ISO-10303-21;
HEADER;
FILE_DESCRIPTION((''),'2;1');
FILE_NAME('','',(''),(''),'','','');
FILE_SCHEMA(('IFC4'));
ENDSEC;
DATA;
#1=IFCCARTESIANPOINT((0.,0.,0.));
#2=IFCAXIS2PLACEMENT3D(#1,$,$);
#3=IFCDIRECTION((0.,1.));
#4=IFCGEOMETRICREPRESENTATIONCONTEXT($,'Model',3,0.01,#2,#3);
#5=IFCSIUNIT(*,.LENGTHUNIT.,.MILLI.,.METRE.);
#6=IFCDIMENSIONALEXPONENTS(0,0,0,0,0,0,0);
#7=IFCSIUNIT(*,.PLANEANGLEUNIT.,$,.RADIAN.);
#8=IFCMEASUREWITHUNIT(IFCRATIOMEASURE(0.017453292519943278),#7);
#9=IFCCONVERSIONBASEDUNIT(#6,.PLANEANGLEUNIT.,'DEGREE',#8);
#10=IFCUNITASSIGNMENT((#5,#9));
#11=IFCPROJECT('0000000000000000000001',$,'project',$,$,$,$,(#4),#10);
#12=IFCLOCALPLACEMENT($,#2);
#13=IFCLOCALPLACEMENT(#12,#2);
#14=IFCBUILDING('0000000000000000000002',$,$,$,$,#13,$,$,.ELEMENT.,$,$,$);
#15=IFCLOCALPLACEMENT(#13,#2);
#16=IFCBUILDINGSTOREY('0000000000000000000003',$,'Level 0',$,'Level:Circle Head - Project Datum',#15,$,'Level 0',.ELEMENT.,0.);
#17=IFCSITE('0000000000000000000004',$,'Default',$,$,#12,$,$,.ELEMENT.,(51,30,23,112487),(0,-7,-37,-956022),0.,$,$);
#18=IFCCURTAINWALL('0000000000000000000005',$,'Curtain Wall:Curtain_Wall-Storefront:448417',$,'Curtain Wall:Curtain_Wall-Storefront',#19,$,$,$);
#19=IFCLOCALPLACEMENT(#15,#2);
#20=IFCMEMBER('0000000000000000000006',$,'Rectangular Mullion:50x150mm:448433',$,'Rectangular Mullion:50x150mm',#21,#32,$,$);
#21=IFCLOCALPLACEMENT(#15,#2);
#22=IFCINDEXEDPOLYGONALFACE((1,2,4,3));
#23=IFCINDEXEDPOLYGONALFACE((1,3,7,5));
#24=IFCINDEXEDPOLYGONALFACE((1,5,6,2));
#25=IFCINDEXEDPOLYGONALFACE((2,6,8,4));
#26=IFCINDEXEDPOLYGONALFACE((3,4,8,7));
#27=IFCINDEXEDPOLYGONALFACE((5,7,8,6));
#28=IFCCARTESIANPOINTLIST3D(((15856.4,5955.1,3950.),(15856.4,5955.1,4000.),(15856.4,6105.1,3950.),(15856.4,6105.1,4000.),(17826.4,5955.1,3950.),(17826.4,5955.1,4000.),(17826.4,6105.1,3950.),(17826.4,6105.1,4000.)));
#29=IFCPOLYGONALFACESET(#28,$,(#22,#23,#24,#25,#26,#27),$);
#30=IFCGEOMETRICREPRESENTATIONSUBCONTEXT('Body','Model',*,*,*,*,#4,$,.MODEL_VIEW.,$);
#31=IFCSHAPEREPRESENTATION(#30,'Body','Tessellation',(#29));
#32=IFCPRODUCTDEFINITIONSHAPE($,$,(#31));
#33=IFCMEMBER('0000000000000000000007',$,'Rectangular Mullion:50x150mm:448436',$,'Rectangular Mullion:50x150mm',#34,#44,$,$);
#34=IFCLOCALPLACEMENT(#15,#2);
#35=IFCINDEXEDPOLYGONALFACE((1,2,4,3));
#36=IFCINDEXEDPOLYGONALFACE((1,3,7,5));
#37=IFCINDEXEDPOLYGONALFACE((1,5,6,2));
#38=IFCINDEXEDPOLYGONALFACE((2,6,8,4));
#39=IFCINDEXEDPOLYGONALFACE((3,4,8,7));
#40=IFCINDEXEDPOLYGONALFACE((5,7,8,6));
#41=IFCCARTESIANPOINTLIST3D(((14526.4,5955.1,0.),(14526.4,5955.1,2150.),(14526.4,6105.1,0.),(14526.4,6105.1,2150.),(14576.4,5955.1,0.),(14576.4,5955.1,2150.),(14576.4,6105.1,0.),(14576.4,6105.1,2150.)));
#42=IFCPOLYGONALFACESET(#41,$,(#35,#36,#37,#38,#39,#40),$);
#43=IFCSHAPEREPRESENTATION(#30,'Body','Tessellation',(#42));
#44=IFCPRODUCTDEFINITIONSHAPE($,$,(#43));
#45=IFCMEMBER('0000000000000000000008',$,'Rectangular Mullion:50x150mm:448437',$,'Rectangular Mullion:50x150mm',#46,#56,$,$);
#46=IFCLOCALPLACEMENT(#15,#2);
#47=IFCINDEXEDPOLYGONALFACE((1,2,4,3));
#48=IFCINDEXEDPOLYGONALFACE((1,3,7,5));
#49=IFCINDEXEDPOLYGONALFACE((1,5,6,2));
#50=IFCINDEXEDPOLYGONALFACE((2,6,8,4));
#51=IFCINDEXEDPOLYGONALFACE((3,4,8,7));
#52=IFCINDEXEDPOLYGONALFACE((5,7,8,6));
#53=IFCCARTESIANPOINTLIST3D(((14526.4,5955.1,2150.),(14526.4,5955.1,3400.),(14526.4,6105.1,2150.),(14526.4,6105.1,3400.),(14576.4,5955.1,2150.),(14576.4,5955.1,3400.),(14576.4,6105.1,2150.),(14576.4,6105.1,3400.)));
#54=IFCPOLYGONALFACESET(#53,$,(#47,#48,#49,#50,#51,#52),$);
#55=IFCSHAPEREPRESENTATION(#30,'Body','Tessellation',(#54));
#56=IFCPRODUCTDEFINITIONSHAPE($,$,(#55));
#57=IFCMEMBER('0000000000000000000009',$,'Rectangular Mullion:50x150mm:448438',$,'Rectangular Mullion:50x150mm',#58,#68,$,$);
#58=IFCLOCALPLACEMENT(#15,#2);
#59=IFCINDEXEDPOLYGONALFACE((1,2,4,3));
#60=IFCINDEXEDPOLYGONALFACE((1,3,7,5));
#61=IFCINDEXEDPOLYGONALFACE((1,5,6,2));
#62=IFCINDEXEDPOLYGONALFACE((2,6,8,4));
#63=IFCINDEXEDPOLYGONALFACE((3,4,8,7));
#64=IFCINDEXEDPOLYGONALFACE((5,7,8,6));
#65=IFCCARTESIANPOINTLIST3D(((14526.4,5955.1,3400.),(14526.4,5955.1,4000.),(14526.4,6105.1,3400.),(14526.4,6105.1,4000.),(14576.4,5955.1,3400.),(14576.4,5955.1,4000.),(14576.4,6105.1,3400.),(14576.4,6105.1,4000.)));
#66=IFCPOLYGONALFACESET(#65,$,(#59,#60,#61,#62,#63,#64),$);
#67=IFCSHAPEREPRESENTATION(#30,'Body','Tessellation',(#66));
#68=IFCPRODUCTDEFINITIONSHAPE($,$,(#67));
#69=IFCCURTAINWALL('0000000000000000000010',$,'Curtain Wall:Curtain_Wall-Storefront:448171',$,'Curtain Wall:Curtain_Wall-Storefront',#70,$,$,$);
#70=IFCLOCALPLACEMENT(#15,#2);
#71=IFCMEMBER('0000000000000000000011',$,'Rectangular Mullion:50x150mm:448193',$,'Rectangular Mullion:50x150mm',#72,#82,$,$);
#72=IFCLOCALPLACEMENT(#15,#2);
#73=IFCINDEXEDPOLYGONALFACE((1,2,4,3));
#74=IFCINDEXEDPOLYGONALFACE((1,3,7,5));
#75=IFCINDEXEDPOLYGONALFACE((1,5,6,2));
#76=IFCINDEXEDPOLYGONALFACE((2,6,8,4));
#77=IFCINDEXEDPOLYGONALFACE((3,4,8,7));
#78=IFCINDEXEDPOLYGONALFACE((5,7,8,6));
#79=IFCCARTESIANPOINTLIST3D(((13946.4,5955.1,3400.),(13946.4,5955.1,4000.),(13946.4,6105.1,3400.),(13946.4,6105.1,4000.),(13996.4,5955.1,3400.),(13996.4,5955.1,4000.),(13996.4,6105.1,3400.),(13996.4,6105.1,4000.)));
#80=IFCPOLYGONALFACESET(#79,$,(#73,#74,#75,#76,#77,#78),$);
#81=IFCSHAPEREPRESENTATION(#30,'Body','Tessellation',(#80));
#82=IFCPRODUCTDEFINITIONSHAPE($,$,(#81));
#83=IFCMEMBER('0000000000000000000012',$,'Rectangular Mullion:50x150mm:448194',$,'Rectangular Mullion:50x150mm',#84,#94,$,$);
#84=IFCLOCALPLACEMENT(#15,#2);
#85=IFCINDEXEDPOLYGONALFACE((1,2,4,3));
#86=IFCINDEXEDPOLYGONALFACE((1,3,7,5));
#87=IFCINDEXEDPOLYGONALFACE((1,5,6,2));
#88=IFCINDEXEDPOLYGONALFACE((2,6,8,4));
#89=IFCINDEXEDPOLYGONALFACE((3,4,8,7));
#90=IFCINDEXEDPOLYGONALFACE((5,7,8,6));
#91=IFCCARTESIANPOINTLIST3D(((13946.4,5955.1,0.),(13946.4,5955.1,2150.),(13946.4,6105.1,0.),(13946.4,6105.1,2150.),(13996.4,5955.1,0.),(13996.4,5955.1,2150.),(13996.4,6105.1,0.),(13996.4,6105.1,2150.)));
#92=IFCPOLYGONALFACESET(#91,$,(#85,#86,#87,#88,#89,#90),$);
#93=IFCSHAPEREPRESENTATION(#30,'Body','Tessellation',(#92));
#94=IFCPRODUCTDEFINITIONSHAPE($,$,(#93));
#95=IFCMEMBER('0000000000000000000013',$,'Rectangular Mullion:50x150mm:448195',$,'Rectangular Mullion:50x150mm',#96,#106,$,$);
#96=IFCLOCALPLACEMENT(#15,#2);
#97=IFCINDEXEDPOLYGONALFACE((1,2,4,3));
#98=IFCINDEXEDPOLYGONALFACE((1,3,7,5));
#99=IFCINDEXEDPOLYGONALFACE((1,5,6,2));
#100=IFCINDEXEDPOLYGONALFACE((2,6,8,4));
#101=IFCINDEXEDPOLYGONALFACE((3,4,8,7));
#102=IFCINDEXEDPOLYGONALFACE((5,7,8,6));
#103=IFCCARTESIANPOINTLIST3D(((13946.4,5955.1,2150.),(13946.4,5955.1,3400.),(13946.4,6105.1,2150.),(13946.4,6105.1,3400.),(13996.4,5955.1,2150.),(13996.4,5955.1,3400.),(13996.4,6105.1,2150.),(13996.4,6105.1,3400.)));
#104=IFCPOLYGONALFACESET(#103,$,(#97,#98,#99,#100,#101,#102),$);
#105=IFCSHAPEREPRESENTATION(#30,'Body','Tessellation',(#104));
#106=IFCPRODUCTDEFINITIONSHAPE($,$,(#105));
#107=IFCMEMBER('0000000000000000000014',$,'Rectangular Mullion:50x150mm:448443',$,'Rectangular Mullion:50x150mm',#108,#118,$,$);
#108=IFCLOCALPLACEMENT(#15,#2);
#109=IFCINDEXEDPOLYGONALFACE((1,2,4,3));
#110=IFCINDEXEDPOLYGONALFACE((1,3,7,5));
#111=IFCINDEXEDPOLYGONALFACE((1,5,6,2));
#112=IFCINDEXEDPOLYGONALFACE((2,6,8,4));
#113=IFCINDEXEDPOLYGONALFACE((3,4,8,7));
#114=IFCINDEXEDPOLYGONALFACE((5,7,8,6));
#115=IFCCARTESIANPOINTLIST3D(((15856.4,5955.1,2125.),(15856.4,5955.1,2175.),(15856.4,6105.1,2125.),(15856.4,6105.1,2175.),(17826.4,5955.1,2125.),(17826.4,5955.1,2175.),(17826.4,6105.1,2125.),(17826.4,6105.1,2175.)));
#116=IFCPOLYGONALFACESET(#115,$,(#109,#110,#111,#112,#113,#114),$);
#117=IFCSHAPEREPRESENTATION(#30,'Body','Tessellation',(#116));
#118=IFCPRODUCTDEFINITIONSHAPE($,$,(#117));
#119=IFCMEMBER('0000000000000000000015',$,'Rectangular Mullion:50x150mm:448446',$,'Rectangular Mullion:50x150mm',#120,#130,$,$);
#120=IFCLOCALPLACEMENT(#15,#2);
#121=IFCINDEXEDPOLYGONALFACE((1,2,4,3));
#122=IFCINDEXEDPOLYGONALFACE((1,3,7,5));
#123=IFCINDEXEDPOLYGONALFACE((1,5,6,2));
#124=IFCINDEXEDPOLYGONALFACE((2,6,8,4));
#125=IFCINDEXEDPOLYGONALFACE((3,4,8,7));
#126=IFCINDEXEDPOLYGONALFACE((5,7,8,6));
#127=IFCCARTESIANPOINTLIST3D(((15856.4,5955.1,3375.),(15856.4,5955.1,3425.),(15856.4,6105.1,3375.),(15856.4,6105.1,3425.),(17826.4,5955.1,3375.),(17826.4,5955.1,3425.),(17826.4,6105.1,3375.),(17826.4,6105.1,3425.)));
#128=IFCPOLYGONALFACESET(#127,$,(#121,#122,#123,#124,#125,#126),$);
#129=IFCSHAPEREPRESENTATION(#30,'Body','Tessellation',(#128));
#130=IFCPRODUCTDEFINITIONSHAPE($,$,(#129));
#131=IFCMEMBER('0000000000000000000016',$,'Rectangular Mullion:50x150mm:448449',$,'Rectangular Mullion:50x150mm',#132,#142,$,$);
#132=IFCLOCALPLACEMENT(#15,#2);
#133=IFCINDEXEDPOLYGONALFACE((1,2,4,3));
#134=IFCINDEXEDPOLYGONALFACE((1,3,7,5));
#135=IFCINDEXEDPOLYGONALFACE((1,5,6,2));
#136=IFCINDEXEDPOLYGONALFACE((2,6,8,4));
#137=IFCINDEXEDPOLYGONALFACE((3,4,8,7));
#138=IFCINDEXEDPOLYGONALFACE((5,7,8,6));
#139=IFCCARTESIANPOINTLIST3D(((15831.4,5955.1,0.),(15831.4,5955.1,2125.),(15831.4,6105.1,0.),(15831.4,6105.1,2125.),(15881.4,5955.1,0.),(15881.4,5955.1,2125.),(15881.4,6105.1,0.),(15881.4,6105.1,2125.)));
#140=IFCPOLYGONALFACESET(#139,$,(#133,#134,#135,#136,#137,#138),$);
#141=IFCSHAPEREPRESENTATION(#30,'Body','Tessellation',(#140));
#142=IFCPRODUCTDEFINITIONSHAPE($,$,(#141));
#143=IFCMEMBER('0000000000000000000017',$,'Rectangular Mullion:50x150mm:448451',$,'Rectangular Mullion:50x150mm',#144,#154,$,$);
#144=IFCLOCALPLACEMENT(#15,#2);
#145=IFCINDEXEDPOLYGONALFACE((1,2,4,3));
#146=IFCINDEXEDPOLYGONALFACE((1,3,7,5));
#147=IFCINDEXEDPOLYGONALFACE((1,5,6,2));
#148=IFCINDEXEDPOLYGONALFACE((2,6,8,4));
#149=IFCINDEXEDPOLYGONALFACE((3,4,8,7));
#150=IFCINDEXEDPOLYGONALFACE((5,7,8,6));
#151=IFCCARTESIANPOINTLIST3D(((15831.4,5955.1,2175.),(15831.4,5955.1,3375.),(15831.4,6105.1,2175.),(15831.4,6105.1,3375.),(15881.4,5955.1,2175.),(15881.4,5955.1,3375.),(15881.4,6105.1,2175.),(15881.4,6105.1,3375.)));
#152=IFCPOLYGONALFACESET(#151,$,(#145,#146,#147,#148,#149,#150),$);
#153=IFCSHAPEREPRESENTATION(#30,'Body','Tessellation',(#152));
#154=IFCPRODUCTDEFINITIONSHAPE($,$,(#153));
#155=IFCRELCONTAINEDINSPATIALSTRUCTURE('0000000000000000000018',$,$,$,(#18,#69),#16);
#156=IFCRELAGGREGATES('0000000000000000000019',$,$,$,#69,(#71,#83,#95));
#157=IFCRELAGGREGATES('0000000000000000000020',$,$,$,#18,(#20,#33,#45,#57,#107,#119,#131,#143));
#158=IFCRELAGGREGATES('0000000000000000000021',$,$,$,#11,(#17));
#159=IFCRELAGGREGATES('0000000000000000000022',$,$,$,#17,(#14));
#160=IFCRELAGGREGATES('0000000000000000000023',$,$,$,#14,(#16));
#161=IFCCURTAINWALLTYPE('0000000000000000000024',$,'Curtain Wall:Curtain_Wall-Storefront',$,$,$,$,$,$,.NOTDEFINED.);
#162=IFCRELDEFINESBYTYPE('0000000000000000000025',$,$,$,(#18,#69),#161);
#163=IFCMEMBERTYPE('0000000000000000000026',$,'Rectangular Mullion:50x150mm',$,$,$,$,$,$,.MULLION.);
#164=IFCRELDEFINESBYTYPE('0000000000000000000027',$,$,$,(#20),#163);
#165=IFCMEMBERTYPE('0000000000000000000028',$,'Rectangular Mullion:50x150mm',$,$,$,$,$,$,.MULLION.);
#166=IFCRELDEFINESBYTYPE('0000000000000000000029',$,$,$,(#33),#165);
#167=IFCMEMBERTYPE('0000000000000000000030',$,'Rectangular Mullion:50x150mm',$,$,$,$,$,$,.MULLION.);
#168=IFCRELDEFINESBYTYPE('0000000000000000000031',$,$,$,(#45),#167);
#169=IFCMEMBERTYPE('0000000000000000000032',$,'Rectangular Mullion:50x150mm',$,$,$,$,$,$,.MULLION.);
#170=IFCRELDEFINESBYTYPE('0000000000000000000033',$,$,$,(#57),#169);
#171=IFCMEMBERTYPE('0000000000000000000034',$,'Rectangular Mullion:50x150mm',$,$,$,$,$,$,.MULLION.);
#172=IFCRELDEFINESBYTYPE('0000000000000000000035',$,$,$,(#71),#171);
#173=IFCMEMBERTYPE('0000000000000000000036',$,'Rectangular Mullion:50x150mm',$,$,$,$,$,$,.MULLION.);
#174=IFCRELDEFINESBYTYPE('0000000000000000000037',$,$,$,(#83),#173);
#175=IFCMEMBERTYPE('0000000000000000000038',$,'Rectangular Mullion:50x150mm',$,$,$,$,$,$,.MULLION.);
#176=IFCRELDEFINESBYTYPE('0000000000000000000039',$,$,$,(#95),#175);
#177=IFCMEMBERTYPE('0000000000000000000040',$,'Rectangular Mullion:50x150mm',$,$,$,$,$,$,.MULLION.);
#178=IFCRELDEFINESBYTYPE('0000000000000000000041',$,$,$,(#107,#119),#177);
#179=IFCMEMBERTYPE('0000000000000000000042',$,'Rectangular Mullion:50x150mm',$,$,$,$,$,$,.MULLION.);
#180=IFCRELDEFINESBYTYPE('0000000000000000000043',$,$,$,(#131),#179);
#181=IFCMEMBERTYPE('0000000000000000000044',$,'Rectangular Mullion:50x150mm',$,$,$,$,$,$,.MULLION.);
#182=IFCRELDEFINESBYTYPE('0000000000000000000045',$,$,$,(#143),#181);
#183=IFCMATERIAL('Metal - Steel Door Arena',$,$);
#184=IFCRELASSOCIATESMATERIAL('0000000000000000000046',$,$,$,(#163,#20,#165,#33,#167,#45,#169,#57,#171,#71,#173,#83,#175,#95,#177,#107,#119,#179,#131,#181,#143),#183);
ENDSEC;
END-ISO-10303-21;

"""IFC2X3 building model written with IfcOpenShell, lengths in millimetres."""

from ifc_helpers import new_model, entity, si_unit, converted_unit, direction, frame, origin, origin_2d_with_axis, place, context, subcontext, project, spatial, rectangle, extrude, source, transform, mapped, material, type_object, type_shapes, element, aggregate, save


model = new_model("IFC2X3")

# Units and contexts
model_context = context("Model", 3, precision=0.01, world=origin(), true_north=direction((0.0, 1.0)))
body_context = subcontext(model_context, "Body", "Model", "MODEL_VIEW")
ifc_project = project(units=[si_unit("LENGTHUNIT", "METRE", prefix="MILLI"), converted_unit("PLANEANGLEUNIT", "DEGREE", entity("IfcRatioMeasure", 0.017453292519943278), si_unit("PLANEANGLEUNIT", "RADIAN"), dimensions=[0, 0, 0, 0, 0, 0, 0])], contexts=[model_context])

# Site, building, storey
site_placement = place(None, origin())
site = spatial("IfcSite", under=ifc_project, at=site_placement, Name="Default", CompositionType="ELEMENT", RefLatitude=(51, 30, 23, 112487), RefLongitude=(0, -7, -37, -956022), RefElevation=0.0)
building_placement = place(site_placement, origin())
building = spatial("IfcBuilding", under=site, at=building_placement, CompositionType="ELEMENT")
storey_placement = place(building_placement, origin())
storey = spatial("IfcBuildingStorey", under=building, at=storey_placement, Name="Level 0", ObjectType="Level:Circle Head - Project Datum", LongName="Level 0", CompositionType="ELEMENT", Elevation=0.0)

# Curtain walls, members
curtain_wall_type = type_object("IfcCurtainWallType", Name="Curtain Wall:Curtain_Wall-Storefront", PredefinedType="NOTDEFINED")
curtain_wall_1_placement = place(storey_placement, origin())
curtain_wall_1 = element("IfcCurtainWall", 1, at=curtain_wall_1_placement, inside=storey, type_object=curtain_wall_type, Name="Curtain Wall:Curtain_Wall-Storefront:448417", ObjectType="Curtain Wall:Curtain_Wall-Storefront")
ifc_material_1 = material(Name="Metal - Steel Door Arena")
member_type_1 = type_object("IfcMemberType", Name="Rectangular Mullion:50x150mm", PredefinedType="MULLION", material=ifc_material_1)
shared_shape_1 = source(origin(), body_context, "Body", "SweptSolid", [
    extrude(rectangle(XDim=150.0, YDim=50.0, at=origin_2d_with_axis()), frame((-25.0, 0.0, -1970.0), z_axis=(0.0, 0.0, 1.0), x_axis=(0.0, -1.0, 0.0)), (0.0, 0.0, 1.0), 1970.0),
])
type_shapes(member_type_1, [shared_shape_1])
member_1_placement = place(curtain_wall_1_placement, frame((15856.4, 6030.1, 4000.0), z_axis=(-1.0, 0.0, 0.0), x_axis=(0.0, 0.0, 1.0)))
member_1 = element("IfcMember", 2, at=member_1_placement, type_object=member_type_1, material=ifc_material_1, Name="Rectangular Mullion:50x150mm:448433", ObjectType="Rectangular Mullion:50x150mm", context=body_context, shape_type="MappedRepresentation", body=[
    mapped(shared_shape_1, transform((0.0, 0.0, 0.0), scale=1.0)),
])
member_type_2 = type_object("IfcMemberType", Name="Rectangular Mullion:50x150mm", PredefinedType="MULLION", material=ifc_material_1)
shared_shape_2 = source(origin(), body_context, "Body", "SweptSolid", [
    extrude(rectangle(XDim=150.0, YDim=50.0, at=origin_2d_with_axis()), frame((-25.0, 0.0, -2150.0), z_axis=(0.0, 0.0, 1.0), x_axis=(0.0, -1.0, 0.0)), (0.0, 0.0, 1.0), 2150.0),
])
type_shapes(member_type_2, [shared_shape_2])
member_2_placement = place(curtain_wall_1_placement, frame((14526.4, 6030.1, 0.0), z_axis=(0.0, 0.0, -1.0), x_axis=(-1.0, 0.0, 0.0)))
member_2 = element("IfcMember", 3, at=member_2_placement, type_object=member_type_2, material=ifc_material_1, Name="Rectangular Mullion:50x150mm:448436", ObjectType="Rectangular Mullion:50x150mm", context=body_context, shape_type="MappedRepresentation", body=[
    mapped(shared_shape_2, transform((0.0, 0.0, 0.0), scale=1.0)),
])
member_type_3 = type_object("IfcMemberType", Name="Rectangular Mullion:50x150mm", PredefinedType="MULLION", material=ifc_material_1)
shared_shape_3 = source(origin(), body_context, "Body", "SweptSolid", [
    extrude(rectangle(XDim=150.0, YDim=50.0, at=origin_2d_with_axis()), frame((-25.0, 0.0, -1250.0), z_axis=(0.0, 0.0, 1.0), x_axis=(0.0, -1.0, 0.0)), (0.0, 0.0, 1.0), 1250.0),
])
type_shapes(member_type_3, [shared_shape_3])
member_3_placement = place(curtain_wall_1_placement, frame((14526.4, 6030.1, 2150.0), z_axis=(0.0, 0.0, -1.0), x_axis=(-1.0, 0.0, 0.0)))
member_3 = element("IfcMember", 4, at=member_3_placement, type_object=member_type_3, material=ifc_material_1, Name="Rectangular Mullion:50x150mm:448437", ObjectType="Rectangular Mullion:50x150mm", context=body_context, shape_type="MappedRepresentation", body=[
    mapped(shared_shape_3, transform((0.0, 0.0, 0.0), scale=1.0)),
])
member_type_4 = type_object("IfcMemberType", Name="Rectangular Mullion:50x150mm", PredefinedType="MULLION", material=ifc_material_1)
shared_shape_4 = source(origin(), body_context, "Body", "SweptSolid", [
    extrude(rectangle(XDim=150.0, YDim=50.0, at=origin_2d_with_axis()), frame((-25.0, 0.0, -600.0), z_axis=(0.0, 0.0, 1.0), x_axis=(0.0, -1.0, 0.0)), (0.0, 0.0, 1.0), 600.0),
])
type_shapes(member_type_4, [shared_shape_4])
member_4_placement = place(curtain_wall_1_placement, frame((14526.4, 6030.1, 3400.0), z_axis=(0.0, 0.0, -1.0), x_axis=(-1.0, 0.0, 0.0)))
member_4 = element("IfcMember", 5, at=member_4_placement, type_object=member_type_4, material=ifc_material_1, Name="Rectangular Mullion:50x150mm:448438", ObjectType="Rectangular Mullion:50x150mm", context=body_context, shape_type="MappedRepresentation", body=[
    mapped(shared_shape_4, transform((0.0, 0.0, 0.0), scale=1.0)),
])
curtain_wall_2_placement = place(storey_placement, origin())
curtain_wall_2 = element("IfcCurtainWall", 6, at=curtain_wall_2_placement, inside=storey, type_object=curtain_wall_type, Name="Curtain Wall:Curtain_Wall-Storefront:448171", ObjectType="Curtain Wall:Curtain_Wall-Storefront")
member_type_5 = type_object("IfcMemberType", Name="Rectangular Mullion:50x150mm", PredefinedType="MULLION", material=ifc_material_1)
shared_shape_5 = source(origin(), body_context, "Body", "SweptSolid", [
    extrude(rectangle(XDim=150.0, YDim=50.0, at=origin_2d_with_axis()), frame((-25.0, 0.0, -600.0), z_axis=(0.0, 0.0, 1.0), x_axis=(0.0, -1.0, 0.0)), (0.0, 0.0, 1.0), 600.0),
])
type_shapes(member_type_5, [shared_shape_5])
member_5_placement = place(curtain_wall_2_placement, frame((13996.4, 6030.1, 4000.0)))
member_5 = element("IfcMember", 7, at=member_5_placement, type_object=member_type_5, material=ifc_material_1, Name="Rectangular Mullion:50x150mm:448193", ObjectType="Rectangular Mullion:50x150mm", context=body_context, shape_type="MappedRepresentation", body=[
    mapped(shared_shape_5, transform((0.0, 0.0, 0.0), scale=1.0)),
])
member_type_6 = type_object("IfcMemberType", Name="Rectangular Mullion:50x150mm", PredefinedType="MULLION", material=ifc_material_1)
shared_shape_6 = source(origin(), body_context, "Body", "SweptSolid", [
    extrude(rectangle(XDim=150.0, YDim=50.0, at=origin_2d_with_axis()), frame((-25.0, 0.0, -2150.0), z_axis=(0.0, 0.0, 1.0), x_axis=(0.0, -1.0, 0.0)), (0.0, 0.0, 1.0), 2150.0),
])
type_shapes(member_type_6, [shared_shape_6])
member_6_placement = place(curtain_wall_2_placement, frame((13996.4, 6030.1, 2150.0)))
member_6 = element("IfcMember", 8, at=member_6_placement, type_object=member_type_6, material=ifc_material_1, Name="Rectangular Mullion:50x150mm:448194", ObjectType="Rectangular Mullion:50x150mm", context=body_context, shape_type="MappedRepresentation", body=[
    mapped(shared_shape_6, transform((0.0, 0.0, 0.0), scale=1.0)),
])
member_type_7 = type_object("IfcMemberType", Name="Rectangular Mullion:50x150mm", PredefinedType="MULLION", material=ifc_material_1)
shared_shape_7 = source(origin(), body_context, "Body", "SweptSolid", [
    extrude(rectangle(XDim=150.0, YDim=50.0, at=origin_2d_with_axis()), frame((-25.0, 0.0, -1250.0), z_axis=(0.0, 0.0, 1.0), x_axis=(0.0, -1.0, 0.0)), (0.0, 0.0, 1.0), 1250.0),
])
type_shapes(member_type_7, [shared_shape_7])
member_7_placement = place(curtain_wall_2_placement, frame((13996.4, 6030.1, 3400.0)))
member_7 = element("IfcMember", 9, at=member_7_placement, type_object=member_type_7, material=ifc_material_1, Name="Rectangular Mullion:50x150mm:448195", ObjectType="Rectangular Mullion:50x150mm", context=body_context, shape_type="MappedRepresentation", body=[
    mapped(shared_shape_7, transform((0.0, 0.0, 0.0), scale=1.0)),
])
aggregate(curtain_wall_2, [member_5, member_6, member_7])

# Members
member_type_8 = type_object("IfcMemberType", Name="Rectangular Mullion:50x150mm", PredefinedType="MULLION", material=ifc_material_1)
shared_shape_8 = source(origin(), body_context, "Body", "SweptSolid", [
    extrude(rectangle(XDim=150.0, YDim=50.0, at=origin_2d_with_axis()), frame((0.0, 0.0, -1970.0), z_axis=(0.0, 0.0, 1.0), x_axis=(0.0, -1.0, 0.0)), (0.0, 0.0, 1.0), 1970.0),
])
type_shapes(member_type_8, [shared_shape_8])
member_8_placement = place(curtain_wall_1_placement, frame((15856.4, 6030.1, 2150.0), z_axis=(-1.0, 0.0, 0.0), x_axis=(0.0, 0.0, 1.0)))
member_8 = element("IfcMember", 10, at=member_8_placement, type_object=member_type_8, material=ifc_material_1, Name="Rectangular Mullion:50x150mm:448443", ObjectType="Rectangular Mullion:50x150mm", context=body_context, shape_type="MappedRepresentation", body=[
    mapped(shared_shape_8, transform((0.0, 0.0, 0.0), scale=1.0)),
])
member_9_placement = place(curtain_wall_1_placement, frame((15856.4, 6030.1, 3400.0), z_axis=(-1.0, 0.0, 0.0), x_axis=(0.0, 0.0, 1.0)))
member_9 = element("IfcMember", 11, at=member_9_placement, type_object=member_type_8, material=ifc_material_1, Name="Rectangular Mullion:50x150mm:448446", ObjectType="Rectangular Mullion:50x150mm", context=body_context, shape_type="MappedRepresentation", body=[
    mapped(shared_shape_8, transform((0.0, 0.0, 0.0), scale=1.0)),
])
member_type_9 = type_object("IfcMemberType", Name="Rectangular Mullion:50x150mm", PredefinedType="MULLION", material=ifc_material_1)
shared_shape_9 = source(origin(), body_context, "Body", "SweptSolid", [
    extrude(rectangle(XDim=150.0, YDim=50.0, at=origin_2d_with_axis()), frame((0.0, 0.0, -2125.0), z_axis=(0.0, 0.0, 1.0), x_axis=(0.0, -1.0, 0.0)), (0.0, 0.0, 1.0), 2125.0),
])
type_shapes(member_type_9, [shared_shape_9])
member_10_placement = place(curtain_wall_1_placement, frame((15856.4, 6030.1, 0.0), z_axis=(0.0, 0.0, -1.0), x_axis=(-1.0, 0.0, 0.0)))
member_10 = element("IfcMember", 12, at=member_10_placement, type_object=member_type_9, material=ifc_material_1, Name="Rectangular Mullion:50x150mm:448449", ObjectType="Rectangular Mullion:50x150mm", context=body_context, shape_type="MappedRepresentation", body=[
    mapped(shared_shape_9, transform((0.0, 0.0, 0.0), scale=1.0)),
])
member_type_10 = type_object("IfcMemberType", Name="Rectangular Mullion:50x150mm", PredefinedType="MULLION", material=ifc_material_1)
shared_shape_10 = source(origin(), body_context, "Body", "SweptSolid", [
    extrude(rectangle(XDim=150.0, YDim=50.0, at=origin_2d_with_axis()), frame((0.0, 0.0, -1200.0), z_axis=(0.0, 0.0, 1.0), x_axis=(0.0, -1.0, 0.0)), (0.0, 0.0, 1.0), 1200.0),
])
type_shapes(member_type_10, [shared_shape_10])
member_11_placement = place(curtain_wall_1_placement, frame((15856.4, 6030.1, 2175.0), z_axis=(0.0, 0.0, -1.0), x_axis=(-1.0, 0.0, 0.0)))
member_11 = element("IfcMember", 13, at=member_11_placement, type_object=member_type_10, material=ifc_material_1, Name="Rectangular Mullion:50x150mm:448451", ObjectType="Rectangular Mullion:50x150mm", context=body_context, shape_type="MappedRepresentation", body=[
    mapped(shared_shape_10, transform((0.0, 0.0, 0.0), scale=1.0)),
])

aggregate(curtain_wall_1, [member_1, member_2, member_3, member_4, member_8, member_9, member_10, member_11])

save(model, "model.ifc")
